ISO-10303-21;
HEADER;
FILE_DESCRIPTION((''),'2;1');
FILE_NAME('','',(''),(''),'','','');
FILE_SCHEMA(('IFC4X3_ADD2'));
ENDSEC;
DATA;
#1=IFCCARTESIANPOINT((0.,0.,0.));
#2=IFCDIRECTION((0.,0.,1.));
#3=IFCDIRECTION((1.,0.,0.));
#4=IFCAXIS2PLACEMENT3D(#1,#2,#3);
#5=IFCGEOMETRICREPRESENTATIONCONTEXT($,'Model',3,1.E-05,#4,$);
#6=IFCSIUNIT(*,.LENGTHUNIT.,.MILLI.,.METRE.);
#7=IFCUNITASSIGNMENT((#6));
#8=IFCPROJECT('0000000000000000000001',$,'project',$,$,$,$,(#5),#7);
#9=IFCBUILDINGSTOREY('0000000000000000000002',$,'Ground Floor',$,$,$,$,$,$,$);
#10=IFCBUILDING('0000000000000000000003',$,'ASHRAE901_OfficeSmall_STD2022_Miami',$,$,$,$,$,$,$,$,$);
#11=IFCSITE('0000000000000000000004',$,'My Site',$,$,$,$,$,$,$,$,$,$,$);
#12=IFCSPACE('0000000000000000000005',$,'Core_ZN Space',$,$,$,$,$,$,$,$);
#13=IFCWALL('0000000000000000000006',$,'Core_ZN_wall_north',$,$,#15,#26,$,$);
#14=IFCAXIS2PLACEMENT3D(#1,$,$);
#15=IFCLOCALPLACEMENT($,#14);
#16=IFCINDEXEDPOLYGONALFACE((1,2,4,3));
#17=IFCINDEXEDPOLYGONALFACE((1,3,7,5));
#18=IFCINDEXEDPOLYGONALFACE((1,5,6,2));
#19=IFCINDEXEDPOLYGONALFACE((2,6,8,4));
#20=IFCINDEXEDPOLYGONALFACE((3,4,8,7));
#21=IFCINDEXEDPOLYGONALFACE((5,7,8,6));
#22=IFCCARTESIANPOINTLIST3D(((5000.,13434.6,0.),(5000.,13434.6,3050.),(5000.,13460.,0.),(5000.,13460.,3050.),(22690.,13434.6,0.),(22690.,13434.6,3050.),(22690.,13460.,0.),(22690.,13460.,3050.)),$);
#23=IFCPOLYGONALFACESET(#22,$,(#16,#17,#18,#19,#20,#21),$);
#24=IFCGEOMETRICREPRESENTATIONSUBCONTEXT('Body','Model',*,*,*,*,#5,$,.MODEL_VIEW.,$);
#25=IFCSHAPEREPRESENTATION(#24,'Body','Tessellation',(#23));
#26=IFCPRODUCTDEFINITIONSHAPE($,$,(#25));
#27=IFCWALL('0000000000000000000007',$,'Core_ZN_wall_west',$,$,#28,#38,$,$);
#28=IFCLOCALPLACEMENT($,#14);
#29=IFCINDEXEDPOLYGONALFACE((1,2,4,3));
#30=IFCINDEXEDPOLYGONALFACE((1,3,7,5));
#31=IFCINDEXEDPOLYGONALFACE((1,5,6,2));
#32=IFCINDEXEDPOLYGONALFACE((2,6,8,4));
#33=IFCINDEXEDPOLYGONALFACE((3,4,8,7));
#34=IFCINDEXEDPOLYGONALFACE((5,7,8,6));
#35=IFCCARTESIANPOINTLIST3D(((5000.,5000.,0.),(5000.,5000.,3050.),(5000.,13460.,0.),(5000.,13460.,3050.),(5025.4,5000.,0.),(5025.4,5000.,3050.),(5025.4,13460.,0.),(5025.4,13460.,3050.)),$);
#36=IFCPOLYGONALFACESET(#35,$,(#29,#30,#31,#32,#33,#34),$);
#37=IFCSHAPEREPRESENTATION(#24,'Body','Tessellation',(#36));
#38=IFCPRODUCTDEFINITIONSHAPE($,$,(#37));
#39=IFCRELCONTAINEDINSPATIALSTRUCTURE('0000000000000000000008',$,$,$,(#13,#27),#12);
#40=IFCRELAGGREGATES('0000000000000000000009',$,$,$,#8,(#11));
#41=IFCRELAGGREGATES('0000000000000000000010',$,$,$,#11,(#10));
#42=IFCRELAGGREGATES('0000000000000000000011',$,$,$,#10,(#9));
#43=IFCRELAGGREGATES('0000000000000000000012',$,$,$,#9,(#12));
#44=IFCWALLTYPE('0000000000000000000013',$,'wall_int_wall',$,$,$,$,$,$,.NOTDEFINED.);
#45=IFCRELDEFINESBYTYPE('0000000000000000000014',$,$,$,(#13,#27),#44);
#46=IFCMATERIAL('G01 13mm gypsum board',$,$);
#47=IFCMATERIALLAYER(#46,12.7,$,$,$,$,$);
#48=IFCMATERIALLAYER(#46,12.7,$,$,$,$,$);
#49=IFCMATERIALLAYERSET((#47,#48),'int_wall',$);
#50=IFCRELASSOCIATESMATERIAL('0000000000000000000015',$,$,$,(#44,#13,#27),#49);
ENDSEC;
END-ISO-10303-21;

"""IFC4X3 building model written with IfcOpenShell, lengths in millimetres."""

from ifc_helpers import new_model, si_unit, frame, origin_with_axes, place, context, subcontext, project, spatial, indexed_curve, outline, extrude, material, layer, layer_set, layer_usage, type_object, element, save


model = new_model("IFC4X3")

# Units and contexts
model_context = context("Model", 3, precision=1e-05, world=origin_with_axes())
body_context = subcontext(model_context, "Body", "Model", "MODEL_VIEW")
ifc_project = project(units=[si_unit("LENGTHUNIT", "METRE", prefix="MILLI")], contexts=[model_context])

# Site, building, storey
site = spatial("IfcSite", under=ifc_project, Name="My Site")
building = spatial("IfcBuilding", under=site, Name="ASHRAE901_OfficeSmall_STD2022_Miami")
storey = spatial("IfcBuildingStorey", under=building, Name="Ground Floor")

# Shared definitions
ifc_material = material(Name="G01 13mm gypsum board")
ifc_layer_1 = layer(ifc_material, 12.7)
ifc_layer_2 = layer(ifc_material, 12.7)
ifc_layer_set = layer_set([ifc_layer_1, ifc_layer_2], Name="int_wall")
wall_type = type_object("IfcWallType", Name="wall_int_wall", PredefinedType="NOTDEFINED", material=ifc_layer_set)

# Shared definitions
space_1 = spatial("IfcSpace", under=storey, Name="Core_ZN Space")

# Walls
ifc_layer_usage_1 = layer_usage(ifc_layer_set, "AXIS2", "POSITIVE", 0.0)
wall_1_placement = place(None, frame((22690.0, 13460.0, 0.0), z_axis=(0.0, 0.0, 1.0), x_axis=(-1.0, 0.0, 0.0)))
element("IfcWall", 1, at=wall_1_placement, inside=space_1, type_object=wall_type, material=ifc_layer_usage_1, Name="Core_ZN_wall_north", context=body_context, shape_type="SweptSolid", body=[
    extrude(outline(indexed_curve([(0.0, 0.0), (0.0, 25.4), (17690.0, 25.4), (17690.0, 0.0), (0.0, 0.0)], self_intersect=False)), origin_with_axes(), (0.0, 0.0, 1.0), 3050.0),
])
ifc_layer_usage_2 = layer_usage(ifc_layer_set, "AXIS2", "POSITIVE", 0.0)
wall_2_placement = place(None, frame((5000.0, 13460.0, 0.0), z_axis=(0.0, 0.0, 1.0), x_axis=(0.0, -1.0, 0.0)))
element("IfcWall", 2, at=wall_2_placement, inside=space_1, type_object=wall_type, material=ifc_layer_usage_2, Name="Core_ZN_wall_west", context=body_context, shape_type="SweptSolid", body=[
    extrude(outline(indexed_curve([(0.0, 0.0), (0.0, 25.4), (8460.0, 25.4), (8460.0, 0.0), (0.0, 0.0)], self_intersect=False)), origin_with_axes(), (0.0, 0.0, 1.0), 3050.0),
])

save(model, "model.ifc")
